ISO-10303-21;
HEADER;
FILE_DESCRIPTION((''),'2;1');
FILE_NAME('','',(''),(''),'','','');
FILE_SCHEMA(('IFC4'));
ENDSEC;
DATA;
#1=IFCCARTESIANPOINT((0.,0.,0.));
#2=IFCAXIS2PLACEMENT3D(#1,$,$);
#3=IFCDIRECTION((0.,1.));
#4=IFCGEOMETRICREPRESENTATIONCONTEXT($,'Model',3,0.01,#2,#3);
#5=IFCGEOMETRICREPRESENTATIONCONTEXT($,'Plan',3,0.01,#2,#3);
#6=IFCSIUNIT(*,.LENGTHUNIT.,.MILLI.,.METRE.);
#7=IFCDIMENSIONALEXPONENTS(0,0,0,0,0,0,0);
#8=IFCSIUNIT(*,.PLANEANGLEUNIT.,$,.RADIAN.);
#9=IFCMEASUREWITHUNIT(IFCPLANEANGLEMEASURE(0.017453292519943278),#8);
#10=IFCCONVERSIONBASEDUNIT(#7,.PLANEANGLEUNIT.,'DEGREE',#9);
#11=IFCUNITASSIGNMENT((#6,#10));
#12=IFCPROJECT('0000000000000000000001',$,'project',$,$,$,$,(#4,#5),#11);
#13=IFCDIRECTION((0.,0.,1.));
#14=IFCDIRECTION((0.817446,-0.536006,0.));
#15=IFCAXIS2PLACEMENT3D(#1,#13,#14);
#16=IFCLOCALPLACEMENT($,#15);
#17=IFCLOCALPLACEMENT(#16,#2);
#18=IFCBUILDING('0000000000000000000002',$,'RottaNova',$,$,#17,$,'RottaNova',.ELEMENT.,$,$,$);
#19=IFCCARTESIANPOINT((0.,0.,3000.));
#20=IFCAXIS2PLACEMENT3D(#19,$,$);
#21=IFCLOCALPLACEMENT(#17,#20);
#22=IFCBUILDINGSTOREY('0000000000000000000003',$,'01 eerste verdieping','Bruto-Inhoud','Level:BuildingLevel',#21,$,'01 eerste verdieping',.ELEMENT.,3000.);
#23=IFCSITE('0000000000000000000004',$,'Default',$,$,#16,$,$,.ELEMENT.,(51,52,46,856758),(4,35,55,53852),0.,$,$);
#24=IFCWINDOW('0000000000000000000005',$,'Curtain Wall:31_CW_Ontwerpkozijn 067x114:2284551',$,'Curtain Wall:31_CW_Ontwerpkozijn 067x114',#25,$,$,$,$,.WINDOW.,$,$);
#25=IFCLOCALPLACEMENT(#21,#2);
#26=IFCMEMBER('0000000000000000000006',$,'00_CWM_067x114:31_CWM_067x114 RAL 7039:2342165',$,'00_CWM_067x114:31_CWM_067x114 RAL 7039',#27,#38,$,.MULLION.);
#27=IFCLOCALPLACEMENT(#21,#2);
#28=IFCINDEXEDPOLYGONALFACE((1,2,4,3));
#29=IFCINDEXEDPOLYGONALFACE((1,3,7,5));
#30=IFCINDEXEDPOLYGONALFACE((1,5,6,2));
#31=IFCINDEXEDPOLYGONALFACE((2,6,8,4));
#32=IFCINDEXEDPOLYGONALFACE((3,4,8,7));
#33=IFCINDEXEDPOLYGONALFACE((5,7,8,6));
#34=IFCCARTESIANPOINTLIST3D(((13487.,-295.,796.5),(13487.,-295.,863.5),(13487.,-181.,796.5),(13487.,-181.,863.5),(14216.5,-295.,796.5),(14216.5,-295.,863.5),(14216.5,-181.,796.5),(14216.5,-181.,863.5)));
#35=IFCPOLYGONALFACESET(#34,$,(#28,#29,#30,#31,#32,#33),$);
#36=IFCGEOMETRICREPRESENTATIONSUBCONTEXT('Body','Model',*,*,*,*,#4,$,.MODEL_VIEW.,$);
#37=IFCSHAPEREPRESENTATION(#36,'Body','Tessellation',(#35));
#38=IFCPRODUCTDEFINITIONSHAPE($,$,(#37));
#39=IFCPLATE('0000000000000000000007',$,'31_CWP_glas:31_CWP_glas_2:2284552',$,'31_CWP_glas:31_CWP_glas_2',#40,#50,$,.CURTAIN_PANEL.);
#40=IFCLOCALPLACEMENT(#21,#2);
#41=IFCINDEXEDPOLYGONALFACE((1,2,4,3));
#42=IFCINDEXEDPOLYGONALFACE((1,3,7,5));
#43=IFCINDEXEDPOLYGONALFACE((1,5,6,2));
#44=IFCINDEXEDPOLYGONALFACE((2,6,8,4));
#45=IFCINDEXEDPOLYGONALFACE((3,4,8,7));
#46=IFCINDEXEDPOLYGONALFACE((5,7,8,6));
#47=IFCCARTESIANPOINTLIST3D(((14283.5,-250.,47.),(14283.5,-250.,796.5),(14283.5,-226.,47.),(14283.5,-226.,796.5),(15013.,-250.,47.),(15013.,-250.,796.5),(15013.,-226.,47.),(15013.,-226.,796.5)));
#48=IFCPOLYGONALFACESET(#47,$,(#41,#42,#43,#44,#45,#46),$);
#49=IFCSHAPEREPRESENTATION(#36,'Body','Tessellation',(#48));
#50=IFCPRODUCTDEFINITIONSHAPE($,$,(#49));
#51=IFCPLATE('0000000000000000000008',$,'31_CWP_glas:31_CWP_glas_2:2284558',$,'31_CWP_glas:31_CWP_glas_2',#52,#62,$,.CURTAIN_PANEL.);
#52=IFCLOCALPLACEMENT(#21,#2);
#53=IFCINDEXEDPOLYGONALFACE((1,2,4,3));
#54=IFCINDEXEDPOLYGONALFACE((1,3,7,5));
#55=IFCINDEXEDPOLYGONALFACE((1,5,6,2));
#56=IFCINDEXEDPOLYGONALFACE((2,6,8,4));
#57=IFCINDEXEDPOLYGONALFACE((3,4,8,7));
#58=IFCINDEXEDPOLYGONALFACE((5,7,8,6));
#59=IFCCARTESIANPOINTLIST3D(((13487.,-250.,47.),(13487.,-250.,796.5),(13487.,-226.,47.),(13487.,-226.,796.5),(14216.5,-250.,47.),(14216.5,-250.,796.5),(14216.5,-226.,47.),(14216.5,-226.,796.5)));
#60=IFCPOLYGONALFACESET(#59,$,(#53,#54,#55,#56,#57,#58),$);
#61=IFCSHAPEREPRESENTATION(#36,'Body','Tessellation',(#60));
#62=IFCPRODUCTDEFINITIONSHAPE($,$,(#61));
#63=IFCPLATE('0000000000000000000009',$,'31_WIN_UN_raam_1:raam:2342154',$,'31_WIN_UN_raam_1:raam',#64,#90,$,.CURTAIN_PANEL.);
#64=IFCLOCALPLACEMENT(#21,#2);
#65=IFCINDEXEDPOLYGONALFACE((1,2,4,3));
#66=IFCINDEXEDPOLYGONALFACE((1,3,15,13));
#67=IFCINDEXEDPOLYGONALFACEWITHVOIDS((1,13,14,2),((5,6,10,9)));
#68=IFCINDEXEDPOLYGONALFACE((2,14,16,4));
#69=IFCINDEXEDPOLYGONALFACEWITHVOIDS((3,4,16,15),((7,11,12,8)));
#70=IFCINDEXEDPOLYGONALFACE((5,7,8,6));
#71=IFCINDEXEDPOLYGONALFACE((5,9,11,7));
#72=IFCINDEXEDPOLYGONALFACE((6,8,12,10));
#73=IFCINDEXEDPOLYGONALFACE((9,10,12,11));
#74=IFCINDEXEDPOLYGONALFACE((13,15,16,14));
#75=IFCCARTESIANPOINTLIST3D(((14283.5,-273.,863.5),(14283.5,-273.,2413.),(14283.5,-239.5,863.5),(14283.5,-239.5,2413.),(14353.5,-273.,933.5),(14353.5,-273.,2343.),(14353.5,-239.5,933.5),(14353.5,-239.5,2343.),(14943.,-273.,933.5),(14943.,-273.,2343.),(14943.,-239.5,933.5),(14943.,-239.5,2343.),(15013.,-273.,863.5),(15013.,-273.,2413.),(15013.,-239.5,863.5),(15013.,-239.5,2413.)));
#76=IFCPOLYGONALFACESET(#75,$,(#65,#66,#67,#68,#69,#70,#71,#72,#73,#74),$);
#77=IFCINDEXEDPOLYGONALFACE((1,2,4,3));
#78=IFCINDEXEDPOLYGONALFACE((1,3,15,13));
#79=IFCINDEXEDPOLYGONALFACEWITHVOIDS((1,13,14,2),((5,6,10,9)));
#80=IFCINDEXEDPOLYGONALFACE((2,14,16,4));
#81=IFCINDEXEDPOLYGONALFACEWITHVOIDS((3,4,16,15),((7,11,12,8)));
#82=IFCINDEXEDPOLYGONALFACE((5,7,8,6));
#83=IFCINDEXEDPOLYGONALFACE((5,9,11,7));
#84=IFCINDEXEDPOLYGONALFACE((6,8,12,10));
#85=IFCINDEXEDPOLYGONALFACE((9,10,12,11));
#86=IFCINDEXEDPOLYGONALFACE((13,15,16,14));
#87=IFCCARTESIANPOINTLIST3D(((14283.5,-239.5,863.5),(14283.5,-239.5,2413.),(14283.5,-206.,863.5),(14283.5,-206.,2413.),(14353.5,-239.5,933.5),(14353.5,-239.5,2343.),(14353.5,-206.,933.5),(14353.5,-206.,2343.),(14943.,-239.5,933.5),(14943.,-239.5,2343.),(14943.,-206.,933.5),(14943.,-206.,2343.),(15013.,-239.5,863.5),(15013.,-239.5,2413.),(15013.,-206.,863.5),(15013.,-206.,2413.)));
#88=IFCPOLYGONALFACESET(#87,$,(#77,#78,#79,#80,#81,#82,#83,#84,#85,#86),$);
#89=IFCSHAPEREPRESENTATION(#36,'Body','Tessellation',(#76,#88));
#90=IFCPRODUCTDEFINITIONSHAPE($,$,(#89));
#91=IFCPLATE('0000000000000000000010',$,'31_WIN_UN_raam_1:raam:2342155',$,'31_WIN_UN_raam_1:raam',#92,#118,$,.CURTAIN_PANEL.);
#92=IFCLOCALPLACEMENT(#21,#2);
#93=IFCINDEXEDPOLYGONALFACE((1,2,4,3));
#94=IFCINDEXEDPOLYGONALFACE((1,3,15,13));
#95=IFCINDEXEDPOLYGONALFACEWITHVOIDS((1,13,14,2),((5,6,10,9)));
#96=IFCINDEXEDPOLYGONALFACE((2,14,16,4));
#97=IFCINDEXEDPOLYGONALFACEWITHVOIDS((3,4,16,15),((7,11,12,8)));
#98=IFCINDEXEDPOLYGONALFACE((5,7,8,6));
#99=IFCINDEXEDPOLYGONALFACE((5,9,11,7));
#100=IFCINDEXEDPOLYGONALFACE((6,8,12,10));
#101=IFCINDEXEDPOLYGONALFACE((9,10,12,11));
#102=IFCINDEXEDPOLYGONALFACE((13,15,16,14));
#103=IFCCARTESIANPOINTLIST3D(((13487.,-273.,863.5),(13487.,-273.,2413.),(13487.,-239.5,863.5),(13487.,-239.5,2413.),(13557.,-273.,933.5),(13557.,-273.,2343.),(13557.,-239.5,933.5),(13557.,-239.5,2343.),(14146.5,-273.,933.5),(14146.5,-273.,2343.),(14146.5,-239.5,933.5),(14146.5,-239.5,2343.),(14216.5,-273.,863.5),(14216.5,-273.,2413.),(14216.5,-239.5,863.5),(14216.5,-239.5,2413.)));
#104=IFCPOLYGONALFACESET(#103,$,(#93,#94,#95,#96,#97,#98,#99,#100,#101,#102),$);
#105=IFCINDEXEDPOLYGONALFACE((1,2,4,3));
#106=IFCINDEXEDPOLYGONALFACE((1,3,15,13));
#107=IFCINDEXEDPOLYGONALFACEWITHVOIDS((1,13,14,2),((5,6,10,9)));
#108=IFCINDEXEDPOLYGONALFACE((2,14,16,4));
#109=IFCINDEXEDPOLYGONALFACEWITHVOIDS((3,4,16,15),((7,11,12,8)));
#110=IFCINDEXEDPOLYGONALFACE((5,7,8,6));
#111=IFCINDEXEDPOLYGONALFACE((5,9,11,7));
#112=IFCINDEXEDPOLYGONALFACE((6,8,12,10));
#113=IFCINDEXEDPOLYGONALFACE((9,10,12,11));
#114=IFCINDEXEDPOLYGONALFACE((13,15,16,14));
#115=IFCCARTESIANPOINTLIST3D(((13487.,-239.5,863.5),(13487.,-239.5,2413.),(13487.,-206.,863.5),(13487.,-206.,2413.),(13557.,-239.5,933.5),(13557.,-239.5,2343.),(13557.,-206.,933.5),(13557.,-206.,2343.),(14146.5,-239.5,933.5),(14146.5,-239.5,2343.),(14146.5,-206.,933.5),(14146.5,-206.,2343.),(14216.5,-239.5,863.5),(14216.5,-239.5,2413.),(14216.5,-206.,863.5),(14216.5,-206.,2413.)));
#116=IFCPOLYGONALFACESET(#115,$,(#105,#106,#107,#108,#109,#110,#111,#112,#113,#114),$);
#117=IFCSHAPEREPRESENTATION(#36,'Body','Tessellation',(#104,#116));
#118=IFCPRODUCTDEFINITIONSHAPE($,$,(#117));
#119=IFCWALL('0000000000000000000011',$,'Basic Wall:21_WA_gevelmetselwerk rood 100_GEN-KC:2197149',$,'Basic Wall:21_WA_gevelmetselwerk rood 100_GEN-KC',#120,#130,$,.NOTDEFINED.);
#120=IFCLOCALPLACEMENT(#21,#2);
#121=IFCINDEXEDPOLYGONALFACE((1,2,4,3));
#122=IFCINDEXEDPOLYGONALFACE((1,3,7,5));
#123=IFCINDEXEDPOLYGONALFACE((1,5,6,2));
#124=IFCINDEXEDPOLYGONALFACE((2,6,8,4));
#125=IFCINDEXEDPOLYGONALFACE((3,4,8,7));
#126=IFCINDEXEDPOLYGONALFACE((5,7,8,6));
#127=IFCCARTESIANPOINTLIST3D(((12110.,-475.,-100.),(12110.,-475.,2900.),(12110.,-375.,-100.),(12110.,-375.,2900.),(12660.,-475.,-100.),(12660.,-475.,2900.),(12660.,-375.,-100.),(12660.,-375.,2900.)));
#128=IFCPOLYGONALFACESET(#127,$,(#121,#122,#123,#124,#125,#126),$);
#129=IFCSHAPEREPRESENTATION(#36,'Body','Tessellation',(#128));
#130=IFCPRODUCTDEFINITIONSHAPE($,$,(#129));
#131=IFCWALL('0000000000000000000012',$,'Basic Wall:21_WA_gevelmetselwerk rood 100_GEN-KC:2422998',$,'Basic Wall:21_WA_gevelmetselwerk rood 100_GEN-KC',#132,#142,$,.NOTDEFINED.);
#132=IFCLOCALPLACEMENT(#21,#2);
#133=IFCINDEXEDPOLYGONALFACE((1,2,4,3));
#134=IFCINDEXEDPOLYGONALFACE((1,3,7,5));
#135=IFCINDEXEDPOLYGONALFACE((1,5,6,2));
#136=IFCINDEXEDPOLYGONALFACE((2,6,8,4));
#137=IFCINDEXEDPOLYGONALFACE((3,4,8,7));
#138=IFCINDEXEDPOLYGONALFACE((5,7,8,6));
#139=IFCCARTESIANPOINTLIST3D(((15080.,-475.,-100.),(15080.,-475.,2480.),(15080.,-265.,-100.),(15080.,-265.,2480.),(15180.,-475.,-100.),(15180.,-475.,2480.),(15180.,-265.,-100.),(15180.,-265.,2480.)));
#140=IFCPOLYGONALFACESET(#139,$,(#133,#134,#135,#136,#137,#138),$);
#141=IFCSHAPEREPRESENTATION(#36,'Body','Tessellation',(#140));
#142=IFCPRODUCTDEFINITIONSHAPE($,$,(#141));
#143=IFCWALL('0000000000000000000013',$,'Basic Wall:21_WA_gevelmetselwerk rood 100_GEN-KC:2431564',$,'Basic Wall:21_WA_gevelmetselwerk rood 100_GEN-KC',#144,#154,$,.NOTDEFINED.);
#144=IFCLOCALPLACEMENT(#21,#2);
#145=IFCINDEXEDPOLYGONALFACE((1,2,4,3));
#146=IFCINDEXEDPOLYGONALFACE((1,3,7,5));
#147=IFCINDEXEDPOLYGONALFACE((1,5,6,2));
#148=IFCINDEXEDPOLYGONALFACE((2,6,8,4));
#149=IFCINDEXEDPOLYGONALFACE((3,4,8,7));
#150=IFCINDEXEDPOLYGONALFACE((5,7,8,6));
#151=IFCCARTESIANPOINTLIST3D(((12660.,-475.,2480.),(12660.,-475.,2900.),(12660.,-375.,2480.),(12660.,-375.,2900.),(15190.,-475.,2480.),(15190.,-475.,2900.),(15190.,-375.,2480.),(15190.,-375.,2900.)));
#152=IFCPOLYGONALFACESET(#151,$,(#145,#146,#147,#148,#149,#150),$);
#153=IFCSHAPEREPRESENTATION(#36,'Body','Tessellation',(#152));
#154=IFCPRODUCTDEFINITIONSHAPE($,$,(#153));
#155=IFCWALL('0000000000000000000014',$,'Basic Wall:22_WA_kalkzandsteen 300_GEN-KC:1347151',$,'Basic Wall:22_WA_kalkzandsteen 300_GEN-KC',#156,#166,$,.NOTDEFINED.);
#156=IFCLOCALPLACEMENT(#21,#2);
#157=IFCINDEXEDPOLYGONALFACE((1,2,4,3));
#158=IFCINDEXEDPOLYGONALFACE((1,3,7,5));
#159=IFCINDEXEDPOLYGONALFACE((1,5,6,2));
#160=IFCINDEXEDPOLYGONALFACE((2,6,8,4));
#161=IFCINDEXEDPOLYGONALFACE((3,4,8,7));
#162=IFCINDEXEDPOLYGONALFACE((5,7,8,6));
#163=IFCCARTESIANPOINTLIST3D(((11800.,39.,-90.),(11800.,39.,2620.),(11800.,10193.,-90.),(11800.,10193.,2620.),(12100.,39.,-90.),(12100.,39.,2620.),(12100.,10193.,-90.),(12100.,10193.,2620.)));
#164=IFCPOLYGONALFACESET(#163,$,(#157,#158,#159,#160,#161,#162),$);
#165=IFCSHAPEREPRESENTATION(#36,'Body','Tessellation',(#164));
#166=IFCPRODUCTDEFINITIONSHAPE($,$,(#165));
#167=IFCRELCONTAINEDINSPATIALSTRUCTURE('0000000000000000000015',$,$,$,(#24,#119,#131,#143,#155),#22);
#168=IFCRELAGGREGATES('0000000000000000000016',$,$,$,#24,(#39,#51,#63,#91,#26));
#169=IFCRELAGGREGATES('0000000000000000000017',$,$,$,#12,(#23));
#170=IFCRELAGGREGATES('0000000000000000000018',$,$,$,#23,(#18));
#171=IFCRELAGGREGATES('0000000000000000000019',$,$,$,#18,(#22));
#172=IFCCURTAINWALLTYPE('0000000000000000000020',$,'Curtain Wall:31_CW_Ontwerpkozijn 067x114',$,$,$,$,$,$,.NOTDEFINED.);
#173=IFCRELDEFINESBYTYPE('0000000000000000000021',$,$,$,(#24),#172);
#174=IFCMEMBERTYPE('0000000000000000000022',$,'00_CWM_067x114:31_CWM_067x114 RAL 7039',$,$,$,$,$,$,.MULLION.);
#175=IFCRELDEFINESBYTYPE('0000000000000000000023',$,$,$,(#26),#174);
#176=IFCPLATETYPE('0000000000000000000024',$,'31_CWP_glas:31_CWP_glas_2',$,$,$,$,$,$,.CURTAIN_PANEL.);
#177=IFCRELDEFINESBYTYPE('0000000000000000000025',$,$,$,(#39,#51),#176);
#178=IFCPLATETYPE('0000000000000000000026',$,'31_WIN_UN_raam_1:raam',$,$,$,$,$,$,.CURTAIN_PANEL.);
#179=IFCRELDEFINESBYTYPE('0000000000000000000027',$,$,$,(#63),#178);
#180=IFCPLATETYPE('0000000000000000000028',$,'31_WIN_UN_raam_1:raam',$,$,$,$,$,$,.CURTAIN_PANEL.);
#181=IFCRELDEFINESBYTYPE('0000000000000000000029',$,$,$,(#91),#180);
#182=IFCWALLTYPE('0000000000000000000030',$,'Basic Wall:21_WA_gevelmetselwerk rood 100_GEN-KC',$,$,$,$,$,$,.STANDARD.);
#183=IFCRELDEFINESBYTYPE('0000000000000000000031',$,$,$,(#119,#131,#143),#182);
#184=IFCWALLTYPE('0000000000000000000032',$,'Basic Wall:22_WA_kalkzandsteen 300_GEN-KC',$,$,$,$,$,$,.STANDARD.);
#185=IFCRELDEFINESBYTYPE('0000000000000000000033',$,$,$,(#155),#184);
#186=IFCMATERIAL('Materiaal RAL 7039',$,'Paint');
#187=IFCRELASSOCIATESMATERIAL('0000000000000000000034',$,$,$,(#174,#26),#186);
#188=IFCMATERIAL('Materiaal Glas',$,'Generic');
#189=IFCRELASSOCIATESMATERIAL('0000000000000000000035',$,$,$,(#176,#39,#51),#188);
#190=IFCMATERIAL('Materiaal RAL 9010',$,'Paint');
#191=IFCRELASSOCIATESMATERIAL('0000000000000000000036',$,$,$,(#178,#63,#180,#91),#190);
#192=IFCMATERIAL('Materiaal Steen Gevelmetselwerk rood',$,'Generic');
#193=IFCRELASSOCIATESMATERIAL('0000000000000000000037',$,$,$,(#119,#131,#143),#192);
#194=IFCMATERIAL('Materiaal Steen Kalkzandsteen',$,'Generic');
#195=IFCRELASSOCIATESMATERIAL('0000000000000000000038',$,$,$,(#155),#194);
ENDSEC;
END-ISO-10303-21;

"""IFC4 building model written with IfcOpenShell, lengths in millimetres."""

from ifc_helpers import new_model, entity, si_unit, converted_unit, direction, frame, origin, place, context, subcontext, project, spatial, indexed_curve, outline, extrude, source, transform, mapped, material, type_object, type_shapes, element, aggregate, save


model = new_model("IFC4")

# Units and contexts
model_context = context("Model", 3, precision=0.01, world=origin(), true_north=direction((0.0, 1.0)))
plan_context = context("Plan", 3, precision=0.01, world=origin(), true_north=direction((0.0, 1.0)))
body_context = subcontext(model_context, "Body", "Model", "MODEL_VIEW")
ifc_project = project(units=[si_unit("LENGTHUNIT", "METRE", prefix="MILLI"), converted_unit("PLANEANGLEUNIT", "DEGREE", entity("IfcPlaneAngleMeasure", 0.017453292519943278), si_unit("PLANEANGLEUNIT", "RADIAN"), dimensions=[0, 0, 0, 0, 0, 0, 0])], contexts=[model_context, plan_context])

# Site, building, storey
site_placement = place(None, frame((0.0, 0.0, 0.0), z_axis=(0.0, 0.0, 1.0), x_axis=(0.817446, -0.536006, 0.0)))
site = spatial("IfcSite", under=ifc_project, at=site_placement, Name="Default", CompositionType="ELEMENT", RefLatitude=(51, 52, 46, 856758), RefLongitude=(4, 35, 55, 53852), RefElevation=0.0)
building_placement = place(site_placement, origin())
building = spatial("IfcBuilding", under=site, at=building_placement, Name="RottaNova", LongName="RottaNova", CompositionType="ELEMENT")
storey_placement = place(building_placement, frame((0.0, 0.0, 3000.0)))
storey = spatial("IfcBuildingStorey", under=building, at=storey_placement, Name="01 eerste verdieping", Description="Bruto-Inhoud", ObjectType="Level:BuildingLevel", LongName="01 eerste verdieping", CompositionType="ELEMENT", Elevation=3000.0)

# Window, member, plates
curtain_wall_type = type_object("IfcCurtainWallType", Name="Curtain Wall:31_CW_Ontwerpkozijn 067x114", PredefinedType="NOTDEFINED")
window_placement = place(storey_placement, frame((0.0, 0.0, -3000.0)))
window = element("IfcWindow", 1, at=window_placement, inside=storey, type_object=curtain_wall_type, Name="Curtain Wall:31_CW_Ontwerpkozijn 067x114:2284551", ObjectType="Curtain Wall:31_CW_Ontwerpkozijn 067x114", PredefinedType="WINDOW")
ifc_material_1 = material(Name="Materiaal RAL 7039", Category="Paint")
member_type_1 = type_object("IfcMemberType", Name="00_CWM_067x114:31_CWM_067x114 RAL 7039", PredefinedType="MULLION", material=ifc_material_1)
shared_shape_1 = source(origin(), body_context, "Body", "SweptSolid", [
    extrude(outline(indexed_curve([(-33.5, -57.0), (33.5, -57.0), (33.5, 57.0), (-33.5, 57.0), (-33.5, -57.0)], self_intersect=False)), frame((0.0, -57.0, -729.5), z_axis=(0.0, 0.0, 1.0), x_axis=(-1.0, 0.0, 0.0)), (0.0, 0.0, 1.0), 729.5),
])
type_shapes(member_type_1, [shared_shape_1])
member_1_placement = place(window_placement, frame((13487.0, -181.0, 3830.0), z_axis=(-1.0, 0.0, 0.0), x_axis=(0.0, 0.0, 1.0)))
member_1 = element("IfcMember", 2, at=member_1_placement, type_object=member_type_1, material=ifc_material_1, Name="00_CWM_067x114:31_CWM_067x114 RAL 7039:2342165", ObjectType="00_CWM_067x114:31_CWM_067x114 RAL 7039", PredefinedType="MULLION", context=body_context, shape_type="MappedRepresentation", body=[
    mapped(shared_shape_1, transform((0.0, 0.0, 0.0), scale=1.0)),
])
ifc_material_2 = material(Name="Materiaal Glas", Category="Generic")
plate_type_1 = type_object("IfcPlateType", Name="31_CWP_glas:31_CWP_glas_2", PredefinedType="CURTAIN_PANEL", material=ifc_material_2)
shared_shape_2 = source(origin(), body_context, "Body", "SweptSolid", [
    extrude(outline(indexed_curve([(-12.0, -364.7), (12.0, -364.7), (12.0, 364.7), (-12.0, 364.7), (-12.0, -364.7)], self_intersect=False)), frame((0.0, 57.0, 0.0), z_axis=(0.0, 0.0, 1.0), x_axis=(0.0, 1.0, 0.0)), (0.0, 0.0, 1.0), 749.5),
])
type_shapes(plate_type_1, [shared_shape_2])
plate_1_placement = place(window_placement, frame((14648.3, -181.0, 3047.0), z_axis=(0.0, 0.0, 1.0), x_axis=(-1.0, 0.0, 0.0)))
plate_1 = element("IfcPlate", 3, at=plate_1_placement, type_object=plate_type_1, material=ifc_material_2, Name="31_CWP_glas:31_CWP_glas_2:2284552", ObjectType="31_CWP_glas:31_CWP_glas_2", PredefinedType="CURTAIN_PANEL", context=body_context, shape_type="MappedRepresentation", body=[
    mapped(shared_shape_2, transform((0.0, 0.0, 0.0), scale=1.0)),
])
plate_2_placement = place(window_placement, frame((13851.8, -181.0, 3047.0), z_axis=(0.0, 0.0, 1.0), x_axis=(-1.0, 0.0, 0.0)))
plate_2 = element("IfcPlate", 4, at=plate_2_placement, type_object=plate_type_1, material=ifc_material_2, Name="31_CWP_glas:31_CWP_glas_2:2284558", ObjectType="31_CWP_glas:31_CWP_glas_2", PredefinedType="CURTAIN_PANEL", context=body_context, shape_type="MappedRepresentation", body=[
    mapped(shared_shape_2, transform((0.0, 0.0, 0.0), scale=1.0)),
])
ifc_material_3 = material(Name="Materiaal RAL 9010", Category="Paint")
plate_type_2 = type_object("IfcPlateType", Name="31_WIN_UN_raam_1:raam", PredefinedType="CURTAIN_PANEL", material=ifc_material_3)
shared_shape_3 = source(origin(), body_context, "Body", "SweptSolid", [
    extrude(outline(indexed_curve([(-364.7, -774.7), (364.7, -774.7), (364.7, 774.7), (-364.7, 774.7), (-364.7, -774.7)], self_intersect=False), holes=[indexed_curve([(-294.7, 704.7), (294.7, 704.7), (294.7, -704.8), (-294.7, -704.8), (-294.7, 704.7)], self_intersect=False)]), frame((0.0, 58.5, 774.8), z_axis=(0.0, 1.0, 0.0), x_axis=(1.0, 0.0, 0.0)), (0.0, 0.0, 1.0), 33.5),
    extrude(outline(indexed_curve([(-364.7, -774.7), (364.7, -774.7), (364.7, 774.7), (-364.7, 774.7), (-364.7, -774.7)], self_intersect=False), holes=[indexed_curve([(-294.7, 704.7), (294.7, 704.7), (294.7, -704.8), (-294.7, -704.8), (-294.7, 704.7)], self_intersect=False)]), frame((0.0, 25.0, 774.8), z_axis=(0.0, 1.0, 0.0), x_axis=(1.0, 0.0, 0.0)), (0.0, 0.0, 1.0), 33.5),
])
type_shapes(plate_type_2, [shared_shape_3])
plate_3_placement = place(window_placement, frame((14648.3, -181.0, 3863.5), z_axis=(0.0, 0.0, 1.0), x_axis=(-1.0, 0.0, 0.0)))
plate_3 = element("IfcPlate", 5, at=plate_3_placement, type_object=plate_type_2, material=ifc_material_3, Name="31_WIN_UN_raam_1:raam:2342154", ObjectType="31_WIN_UN_raam_1:raam", PredefinedType="CURTAIN_PANEL", context=body_context, shape_type="MappedRepresentation", body=[
    mapped(shared_shape_3, transform((0.0, 0.0, 0.0), scale=1.0)),
])
plate_type_3 = type_object("IfcPlateType", Name="31_WIN_UN_raam_1:raam", PredefinedType="CURTAIN_PANEL", material=ifc_material_3)
shared_shape_4 = source(origin(), body_context, "Body", "SweptSolid", [
    extrude(outline(indexed_curve([(-364.7, -774.7), (364.7, -774.7), (364.7, 774.7), (-364.7, 774.7), (-364.7, -774.7)], self_intersect=False), holes=[indexed_curve([(-294.7, 704.7), (294.7, 704.7), (294.7, -704.8), (-294.7, -704.8), (-294.7, 704.7)], self_intersect=False)]), frame((0.0, 58.5, 774.8), z_axis=(0.0, 1.0, 0.0), x_axis=(1.0, 0.0, 0.0)), (0.0, 0.0, 1.0), 33.5),
    extrude(outline(indexed_curve([(-364.7, -774.7), (364.7, -774.7), (364.7, 774.7), (-364.7, 774.7), (-364.7, -774.7)], self_intersect=False), holes=[indexed_curve([(-294.7, 704.7), (294.7, 704.7), (294.7, -704.8), (-294.7, -704.8), (-294.7, 704.7)], self_intersect=False)]), frame((0.0, 25.0, 774.8), z_axis=(0.0, 1.0, 0.0), x_axis=(1.0, 0.0, 0.0)), (0.0, 0.0, 1.0), 33.5),
])
type_shapes(plate_type_3, [shared_shape_4])
plate_4_placement = place(window_placement, frame((13851.8, -181.0, 3863.5), z_axis=(0.0, 0.0, 1.0), x_axis=(-1.0, 0.0, 0.0)))
plate_4 = element("IfcPlate", 6, at=plate_4_placement, type_object=plate_type_3, material=ifc_material_3, Name="31_WIN_UN_raam_1:raam:2342155", ObjectType="31_WIN_UN_raam_1:raam", PredefinedType="CURTAIN_PANEL", context=body_context, shape_type="MappedRepresentation", body=[
    mapped(shared_shape_4, transform((0.0, 0.0, 0.0), scale=1.0)),
])
aggregate(window, [plate_1, plate_2, plate_3, plate_4, member_1])

# Walls
ifc_material_4 = material(Name="Materiaal Steen Gevelmetselwerk rood", Category="Generic")
wall_type_1 = type_object("IfcWallType", Name="Basic Wall:21_WA_gevelmetselwerk rood 100_GEN-KC", PredefinedType="STANDARD")
wall_1_placement = place(storey_placement, frame((12660.0, -425.0, -100.0), z_axis=(0.0, 0.0, 1.0), x_axis=(-1.0, 0.0, 0.0)))
element("IfcWall", 7, at=wall_1_placement, inside=storey, type_object=wall_type_1, material=ifc_material_4, Name="Basic Wall:21_WA_gevelmetselwerk rood 100_GEN-KC:2197149", ObjectType="Basic Wall:21_WA_gevelmetselwerk rood 100_GEN-KC", PredefinedType="NOTDEFINED", context=body_context, shape_type="SweptSolid", body=[
    extrude(outline(indexed_curve([(550.0, 50.0), (0.0, 50.0), (0.0, -50.0), (550.0, -50.0), (550.0, 50.0)], self_intersect=False)), origin(), (0.0, 0.0, 1.0), 3000.0),
])
wall_2_placement = place(storey_placement, frame((15130.0, -265.0, -100.0), z_axis=(0.0, 0.0, 1.0), x_axis=(0.0, -1.0, 0.0)))
element("IfcWall", 8, at=wall_2_placement, inside=storey, type_object=wall_type_1, material=ifc_material_4, Name="Basic Wall:21_WA_gevelmetselwerk rood 100_GEN-KC:2422998", ObjectType="Basic Wall:21_WA_gevelmetselwerk rood 100_GEN-KC", PredefinedType="NOTDEFINED", context=body_context, shape_type="SweptSolid", body=[
    extrude(outline(indexed_curve([(210.0, 50.0), (0.0, 50.0), (0.0, -50.0), (210.0, -50.0), (210.0, 50.0)], self_intersect=False)), origin(), (0.0, 0.0, 1.0), 2580.0),
])
wall_3_placement = place(storey_placement, frame((15190.0, -425.0, 2480.0), z_axis=(0.0, 0.0, 1.0), x_axis=(-1.0, 0.0, 0.0)))
element("IfcWall", 9, at=wall_3_placement, inside=storey, type_object=wall_type_1, material=ifc_material_4, Name="Basic Wall:21_WA_gevelmetselwerk rood 100_GEN-KC:2431564", ObjectType="Basic Wall:21_WA_gevelmetselwerk rood 100_GEN-KC", PredefinedType="NOTDEFINED", context=body_context, shape_type="SweptSolid", body=[
    extrude(outline(indexed_curve([(2530.0, 50.0), (0.0, 50.0), (0.0, -50.0), (2530.0, -50.0), (2530.0, 50.0)], self_intersect=False)), origin(), (0.0, 0.0, 1.0), 420.0),
])
ifc_material_5 = material(Name="Materiaal Steen Kalkzandsteen", Category="Generic")
wall_type_2 = type_object("IfcWallType", Name="Basic Wall:22_WA_kalkzandsteen 300_GEN-KC", PredefinedType="STANDARD")
wall_4_placement = place(storey_placement, frame((11950.0, 39.0, -90.0), z_axis=(0.0, 0.0, 1.0), x_axis=(0.0, 1.0, 0.0)))
element("IfcWall", 10, at=wall_4_placement, inside=storey, type_object=wall_type_2, material=ifc_material_5, Name="Basic Wall:22_WA_kalkzandsteen 300_GEN-KC:1347151", ObjectType="Basic Wall:22_WA_kalkzandsteen 300_GEN-KC", PredefinedType="NOTDEFINED", context=body_context, shape_type="SweptSolid", body=[
    extrude(outline(indexed_curve([(10154.0, 150.0), (0.0, 150.0), (0.0, -150.0), (10154.0, -150.0), (10154.0, 150.0)], self_intersect=False)), origin(), (0.0, 0.0, 1.0), 2710.0),
])

save(model, "model.ifc")
